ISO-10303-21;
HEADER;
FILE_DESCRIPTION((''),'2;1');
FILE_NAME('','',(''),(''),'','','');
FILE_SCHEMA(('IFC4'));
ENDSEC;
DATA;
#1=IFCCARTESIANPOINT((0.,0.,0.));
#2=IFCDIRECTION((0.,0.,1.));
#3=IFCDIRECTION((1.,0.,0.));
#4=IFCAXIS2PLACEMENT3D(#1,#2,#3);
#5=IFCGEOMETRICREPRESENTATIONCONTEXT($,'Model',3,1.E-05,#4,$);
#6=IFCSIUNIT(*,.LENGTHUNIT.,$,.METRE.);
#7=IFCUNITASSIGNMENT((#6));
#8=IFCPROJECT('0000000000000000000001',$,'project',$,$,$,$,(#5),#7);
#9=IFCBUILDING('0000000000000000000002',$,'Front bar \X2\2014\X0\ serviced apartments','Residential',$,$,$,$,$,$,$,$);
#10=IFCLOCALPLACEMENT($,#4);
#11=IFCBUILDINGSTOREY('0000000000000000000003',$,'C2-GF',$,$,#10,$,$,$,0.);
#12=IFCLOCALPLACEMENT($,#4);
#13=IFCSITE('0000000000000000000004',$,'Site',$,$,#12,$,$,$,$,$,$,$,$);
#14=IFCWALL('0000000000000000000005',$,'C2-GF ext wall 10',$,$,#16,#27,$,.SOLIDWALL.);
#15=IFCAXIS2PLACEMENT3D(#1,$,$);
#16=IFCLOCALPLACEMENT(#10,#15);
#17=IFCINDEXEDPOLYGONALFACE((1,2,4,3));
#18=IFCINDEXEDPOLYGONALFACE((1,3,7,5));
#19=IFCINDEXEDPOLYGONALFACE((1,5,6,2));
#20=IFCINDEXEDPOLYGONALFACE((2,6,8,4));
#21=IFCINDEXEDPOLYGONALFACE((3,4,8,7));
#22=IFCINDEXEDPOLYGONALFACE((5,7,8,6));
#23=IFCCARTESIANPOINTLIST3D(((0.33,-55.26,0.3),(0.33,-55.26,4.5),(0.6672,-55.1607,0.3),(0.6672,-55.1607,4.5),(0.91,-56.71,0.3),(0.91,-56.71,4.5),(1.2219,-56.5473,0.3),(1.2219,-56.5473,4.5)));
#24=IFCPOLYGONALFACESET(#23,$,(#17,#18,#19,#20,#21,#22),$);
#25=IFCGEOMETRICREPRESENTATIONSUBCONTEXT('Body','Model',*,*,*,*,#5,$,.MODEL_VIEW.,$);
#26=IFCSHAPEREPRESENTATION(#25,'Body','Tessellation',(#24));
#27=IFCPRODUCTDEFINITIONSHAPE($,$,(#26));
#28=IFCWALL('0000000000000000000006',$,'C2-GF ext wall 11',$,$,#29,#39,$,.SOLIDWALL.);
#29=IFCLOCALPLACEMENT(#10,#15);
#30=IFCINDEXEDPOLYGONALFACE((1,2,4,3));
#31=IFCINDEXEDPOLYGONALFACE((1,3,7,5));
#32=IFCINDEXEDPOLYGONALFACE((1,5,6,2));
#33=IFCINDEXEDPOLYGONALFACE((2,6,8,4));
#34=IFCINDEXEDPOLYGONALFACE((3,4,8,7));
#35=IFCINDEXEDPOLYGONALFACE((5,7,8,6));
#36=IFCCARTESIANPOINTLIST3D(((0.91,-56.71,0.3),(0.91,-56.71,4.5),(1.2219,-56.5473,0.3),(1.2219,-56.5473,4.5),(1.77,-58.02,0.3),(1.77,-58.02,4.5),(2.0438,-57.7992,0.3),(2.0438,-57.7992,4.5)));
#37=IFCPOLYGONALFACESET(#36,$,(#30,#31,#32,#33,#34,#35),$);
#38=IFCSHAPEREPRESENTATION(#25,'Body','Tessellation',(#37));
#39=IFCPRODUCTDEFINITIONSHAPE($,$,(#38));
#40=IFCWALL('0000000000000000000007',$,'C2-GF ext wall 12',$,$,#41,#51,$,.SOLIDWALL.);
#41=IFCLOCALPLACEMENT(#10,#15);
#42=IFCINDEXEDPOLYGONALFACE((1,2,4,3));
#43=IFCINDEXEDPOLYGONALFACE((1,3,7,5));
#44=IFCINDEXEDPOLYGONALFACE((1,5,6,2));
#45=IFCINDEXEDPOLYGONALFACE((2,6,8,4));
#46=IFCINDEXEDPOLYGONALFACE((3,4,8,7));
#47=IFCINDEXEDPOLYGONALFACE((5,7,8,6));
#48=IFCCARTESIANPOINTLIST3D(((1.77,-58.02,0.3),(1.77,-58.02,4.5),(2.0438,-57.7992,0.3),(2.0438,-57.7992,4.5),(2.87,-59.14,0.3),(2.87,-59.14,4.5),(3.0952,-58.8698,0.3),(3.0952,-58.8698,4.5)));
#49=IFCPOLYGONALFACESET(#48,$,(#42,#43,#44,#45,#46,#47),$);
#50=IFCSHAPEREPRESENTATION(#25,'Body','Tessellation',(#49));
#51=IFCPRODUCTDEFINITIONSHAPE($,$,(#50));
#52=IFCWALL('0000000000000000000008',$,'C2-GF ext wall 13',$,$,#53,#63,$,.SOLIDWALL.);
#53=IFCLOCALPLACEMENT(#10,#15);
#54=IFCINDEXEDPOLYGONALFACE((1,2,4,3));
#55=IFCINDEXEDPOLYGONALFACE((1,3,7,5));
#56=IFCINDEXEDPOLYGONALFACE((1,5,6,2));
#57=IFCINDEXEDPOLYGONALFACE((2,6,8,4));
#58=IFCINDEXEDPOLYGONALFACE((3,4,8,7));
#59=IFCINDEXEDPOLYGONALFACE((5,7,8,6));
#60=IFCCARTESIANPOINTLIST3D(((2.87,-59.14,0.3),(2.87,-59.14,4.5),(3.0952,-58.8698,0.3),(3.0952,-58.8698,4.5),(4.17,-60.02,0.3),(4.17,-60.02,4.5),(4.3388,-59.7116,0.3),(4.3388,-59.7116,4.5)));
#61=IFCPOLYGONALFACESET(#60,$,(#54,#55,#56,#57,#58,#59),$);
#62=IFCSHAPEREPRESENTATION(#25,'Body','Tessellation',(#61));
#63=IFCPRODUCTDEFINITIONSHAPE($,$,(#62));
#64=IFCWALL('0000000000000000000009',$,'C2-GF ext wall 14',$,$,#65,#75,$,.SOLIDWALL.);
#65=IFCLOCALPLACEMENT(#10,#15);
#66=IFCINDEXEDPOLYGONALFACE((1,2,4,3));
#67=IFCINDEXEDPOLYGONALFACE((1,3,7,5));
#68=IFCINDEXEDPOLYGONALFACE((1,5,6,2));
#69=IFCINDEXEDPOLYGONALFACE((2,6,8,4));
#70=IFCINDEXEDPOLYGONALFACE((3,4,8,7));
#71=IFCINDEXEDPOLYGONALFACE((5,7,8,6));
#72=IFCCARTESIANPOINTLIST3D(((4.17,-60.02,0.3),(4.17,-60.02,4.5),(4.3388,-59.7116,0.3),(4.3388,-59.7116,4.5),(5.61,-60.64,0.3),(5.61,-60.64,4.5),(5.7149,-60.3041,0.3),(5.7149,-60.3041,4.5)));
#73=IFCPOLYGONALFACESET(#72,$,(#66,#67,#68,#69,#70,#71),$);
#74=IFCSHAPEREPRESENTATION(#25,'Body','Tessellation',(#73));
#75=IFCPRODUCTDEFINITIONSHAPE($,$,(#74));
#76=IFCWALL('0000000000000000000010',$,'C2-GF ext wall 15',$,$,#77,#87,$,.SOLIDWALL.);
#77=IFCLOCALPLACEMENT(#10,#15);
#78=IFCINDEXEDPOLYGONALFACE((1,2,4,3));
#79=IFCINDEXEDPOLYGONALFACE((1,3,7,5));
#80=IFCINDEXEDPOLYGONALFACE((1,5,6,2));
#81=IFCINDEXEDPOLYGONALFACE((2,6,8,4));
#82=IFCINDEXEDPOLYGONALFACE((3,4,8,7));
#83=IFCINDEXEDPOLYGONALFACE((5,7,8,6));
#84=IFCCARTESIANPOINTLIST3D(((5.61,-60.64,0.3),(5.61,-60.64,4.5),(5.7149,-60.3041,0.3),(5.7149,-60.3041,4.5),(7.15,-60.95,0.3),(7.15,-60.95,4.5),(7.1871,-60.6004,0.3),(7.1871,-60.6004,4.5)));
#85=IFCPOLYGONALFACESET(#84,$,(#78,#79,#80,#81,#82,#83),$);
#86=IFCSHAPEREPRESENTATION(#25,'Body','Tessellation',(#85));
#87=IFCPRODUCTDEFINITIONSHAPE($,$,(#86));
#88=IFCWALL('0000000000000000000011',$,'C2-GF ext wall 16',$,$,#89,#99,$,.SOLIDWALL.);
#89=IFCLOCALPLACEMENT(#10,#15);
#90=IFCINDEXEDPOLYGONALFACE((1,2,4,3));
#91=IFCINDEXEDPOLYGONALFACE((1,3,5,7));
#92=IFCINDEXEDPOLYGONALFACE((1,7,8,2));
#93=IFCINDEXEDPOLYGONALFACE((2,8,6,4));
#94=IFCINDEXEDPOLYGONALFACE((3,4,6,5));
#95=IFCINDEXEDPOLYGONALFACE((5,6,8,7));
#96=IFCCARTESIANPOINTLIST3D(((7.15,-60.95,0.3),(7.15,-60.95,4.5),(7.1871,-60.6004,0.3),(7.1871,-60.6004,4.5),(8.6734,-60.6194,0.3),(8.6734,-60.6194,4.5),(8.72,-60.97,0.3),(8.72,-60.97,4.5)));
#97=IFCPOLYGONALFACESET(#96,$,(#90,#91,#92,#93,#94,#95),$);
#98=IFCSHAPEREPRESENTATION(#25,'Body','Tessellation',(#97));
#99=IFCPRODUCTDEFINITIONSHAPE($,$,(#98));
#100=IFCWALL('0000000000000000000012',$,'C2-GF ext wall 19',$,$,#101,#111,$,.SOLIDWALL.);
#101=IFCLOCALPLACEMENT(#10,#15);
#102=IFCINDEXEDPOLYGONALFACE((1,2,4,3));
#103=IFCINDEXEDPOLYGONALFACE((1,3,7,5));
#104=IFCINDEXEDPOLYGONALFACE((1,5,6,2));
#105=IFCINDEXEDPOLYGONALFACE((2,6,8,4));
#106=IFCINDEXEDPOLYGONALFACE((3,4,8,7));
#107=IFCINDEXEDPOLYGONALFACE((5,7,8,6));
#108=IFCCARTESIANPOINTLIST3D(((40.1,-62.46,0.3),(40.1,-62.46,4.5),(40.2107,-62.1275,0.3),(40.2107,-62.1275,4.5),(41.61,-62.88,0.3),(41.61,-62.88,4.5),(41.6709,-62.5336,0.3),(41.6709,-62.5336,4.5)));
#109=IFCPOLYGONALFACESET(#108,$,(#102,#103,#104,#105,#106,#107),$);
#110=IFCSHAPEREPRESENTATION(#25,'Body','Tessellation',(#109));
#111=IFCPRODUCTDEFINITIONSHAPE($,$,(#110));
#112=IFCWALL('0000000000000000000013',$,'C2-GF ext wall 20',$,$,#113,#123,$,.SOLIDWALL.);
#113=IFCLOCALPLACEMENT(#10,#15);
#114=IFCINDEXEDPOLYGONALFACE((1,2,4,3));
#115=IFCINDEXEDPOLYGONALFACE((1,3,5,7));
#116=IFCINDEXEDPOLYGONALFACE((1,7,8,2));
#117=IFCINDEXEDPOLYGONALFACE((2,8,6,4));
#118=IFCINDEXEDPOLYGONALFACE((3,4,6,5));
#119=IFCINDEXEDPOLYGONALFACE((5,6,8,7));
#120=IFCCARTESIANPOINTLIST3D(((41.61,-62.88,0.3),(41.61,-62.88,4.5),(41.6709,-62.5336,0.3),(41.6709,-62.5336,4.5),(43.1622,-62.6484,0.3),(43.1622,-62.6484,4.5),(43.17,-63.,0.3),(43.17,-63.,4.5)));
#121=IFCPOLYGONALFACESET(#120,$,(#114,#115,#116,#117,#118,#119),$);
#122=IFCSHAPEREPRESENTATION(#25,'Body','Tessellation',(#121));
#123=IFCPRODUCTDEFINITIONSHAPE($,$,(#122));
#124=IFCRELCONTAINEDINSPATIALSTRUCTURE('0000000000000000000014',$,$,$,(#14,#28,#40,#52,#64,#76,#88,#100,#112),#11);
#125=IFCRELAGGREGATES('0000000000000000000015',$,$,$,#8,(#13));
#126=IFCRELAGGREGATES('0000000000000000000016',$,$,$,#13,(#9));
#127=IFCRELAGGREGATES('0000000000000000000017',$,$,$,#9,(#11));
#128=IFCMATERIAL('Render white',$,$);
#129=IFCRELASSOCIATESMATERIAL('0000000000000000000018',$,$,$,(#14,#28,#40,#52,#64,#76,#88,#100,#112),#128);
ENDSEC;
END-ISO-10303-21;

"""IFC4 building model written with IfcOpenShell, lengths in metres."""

from ifc_helpers import new_model, si_unit, frame, origin_with_axes, place, context, subcontext, project, spatial, polyline, outline, extrude, material, element, save


model = new_model("IFC4")

# Units and contexts
model_context = context("Model", 3, precision=1e-05, world=origin_with_axes())
body_context = subcontext(model_context, "Body", "Model", "MODEL_VIEW")
ifc_project = project(units=[si_unit("LENGTHUNIT", "METRE")], contexts=[model_context])

# Site, building, storey
site_placement = place(None, origin_with_axes())
site = spatial("IfcSite", under=ifc_project, at=site_placement, Name="Site")
building = spatial("IfcBuilding", under=site, Name="Front bar — serviced apartments", Description="Residential")
storey_placement = place(None, origin_with_axes())
storey = spatial("IfcBuildingStorey", under=building, at=storey_placement, Name="C2-GF", Elevation=0.0)

# Walls
ifc_material_1 = material(Name="Render white")
wall_1_placement = place(storey_placement, origin_with_axes())
element("IfcWall", 1, at=wall_1_placement, inside=storey, material=ifc_material_1, Name="C2-GF ext wall 10", PredefinedType="SOLIDWALL", context=body_context, shape_type="SweptSolid", body=[
    extrude(outline(polyline([(0.33, -55.26), (0.91, -56.71), (1.2219, -56.5473), (0.6672, -55.1607), (0.33, -55.26)])), frame((0.0, 0.0, 0.3), z_axis=(0.0, 0.0, 1.0), x_axis=(1.0, 0.0, 0.0)), (0.0, 0.0, 1.0), 4.2),
])
wall_2_placement = place(storey_placement, origin_with_axes())
element("IfcWall", 2, at=wall_2_placement, inside=storey, material=ifc_material_1, Name="C2-GF ext wall 11", PredefinedType="SOLIDWALL", context=body_context, shape_type="SweptSolid", body=[
    extrude(outline(polyline([(0.91, -56.71), (1.77, -58.02), (2.0438, -57.7992), (1.2219, -56.5473), (0.91, -56.71)])), frame((0.0, 0.0, 0.3), z_axis=(0.0, 0.0, 1.0), x_axis=(1.0, 0.0, 0.0)), (0.0, 0.0, 1.0), 4.2),
])
wall_3_placement = place(storey_placement, origin_with_axes())
element("IfcWall", 3, at=wall_3_placement, inside=storey, material=ifc_material_1, Name="C2-GF ext wall 12", PredefinedType="SOLIDWALL", context=body_context, shape_type="SweptSolid", body=[
    extrude(outline(polyline([(1.77, -58.02), (2.87, -59.14), (3.0952, -58.8698), (2.0438, -57.7992), (1.77, -58.02)])), frame((0.0, 0.0, 0.3), z_axis=(0.0, 0.0, 1.0), x_axis=(1.0, 0.0, 0.0)), (0.0, 0.0, 1.0), 4.2),
])
wall_4_placement = place(storey_placement, origin_with_axes())
element("IfcWall", 4, at=wall_4_placement, inside=storey, material=ifc_material_1, Name="C2-GF ext wall 13", PredefinedType="SOLIDWALL", context=body_context, shape_type="SweptSolid", body=[
    extrude(outline(polyline([(2.87, -59.14), (4.17, -60.02), (4.3388, -59.7116), (3.0952, -58.8698), (2.87, -59.14)])), frame((0.0, 0.0, 0.3), z_axis=(0.0, 0.0, 1.0), x_axis=(1.0, 0.0, 0.0)), (0.0, 0.0, 1.0), 4.2),
])
wall_5_placement = place(storey_placement, origin_with_axes())
element("IfcWall", 5, at=wall_5_placement, inside=storey, material=ifc_material_1, Name="C2-GF ext wall 14", PredefinedType="SOLIDWALL", context=body_context, shape_type="SweptSolid", body=[
    extrude(outline(polyline([(4.17, -60.02), (5.61, -60.64), (5.7149, -60.3041), (4.3388, -59.7116), (4.17, -60.02)])), frame((0.0, 0.0, 0.3), z_axis=(0.0, 0.0, 1.0), x_axis=(1.0, 0.0, 0.0)), (0.0, 0.0, 1.0), 4.2),
])
wall_6_placement = place(storey_placement, origin_with_axes())
element("IfcWall", 6, at=wall_6_placement, inside=storey, material=ifc_material_1, Name="C2-GF ext wall 15", PredefinedType="SOLIDWALL", context=body_context, shape_type="SweptSolid", body=[
    extrude(outline(polyline([(5.61, -60.64), (7.15, -60.95), (7.1871, -60.6004), (5.7149, -60.3041), (5.61, -60.64)])), frame((0.0, 0.0, 0.3), z_axis=(0.0, 0.0, 1.0), x_axis=(1.0, 0.0, 0.0)), (0.0, 0.0, 1.0), 4.2),
])
wall_7_placement = place(storey_placement, origin_with_axes())
element("IfcWall", 7, at=wall_7_placement, inside=storey, material=ifc_material_1, Name="C2-GF ext wall 16", PredefinedType="SOLIDWALL", context=body_context, shape_type="SweptSolid", body=[
    extrude(outline(polyline([(7.15, -60.95), (8.72, -60.97), (8.6734, -60.6194), (7.1871, -60.6004), (7.15, -60.95)])), frame((0.0, 0.0, 0.3), z_axis=(0.0, 0.0, 1.0), x_axis=(1.0, 0.0, 0.0)), (0.0, 0.0, 1.0), 4.2),
])

# Walls
wall_8_placement = place(storey_placement, origin_with_axes())
element("IfcWall", 8, at=wall_8_placement, inside=storey, material=ifc_material_1, Name="C2-GF ext wall 19", PredefinedType="SOLIDWALL", context=body_context, shape_type="SweptSolid", body=[
    extrude(outline(polyline([(40.1, -62.46), (41.61, -62.88), (41.6709, -62.5336), (40.2107, -62.1275), (40.1, -62.46)])), frame((0.0, 0.0, 0.3), z_axis=(0.0, 0.0, 1.0), x_axis=(1.0, 0.0, 0.0)), (0.0, 0.0, 1.0), 4.2),
])
wall_9_placement = place(storey_placement, origin_with_axes())
element("IfcWall", 9, at=wall_9_placement, inside=storey, material=ifc_material_1, Name="C2-GF ext wall 20", PredefinedType="SOLIDWALL", context=body_context, shape_type="SweptSolid", body=[
    extrude(outline(polyline([(41.61, -62.88), (43.17, -63.0), (43.1622, -62.6484), (41.6709, -62.5336), (41.61, -62.88)])), frame((0.0, 0.0, 0.3), z_axis=(0.0, 0.0, 1.0), x_axis=(1.0, 0.0, 0.0)), (0.0, 0.0, 1.0), 4.2),
])

save(model, "model.ifc")
